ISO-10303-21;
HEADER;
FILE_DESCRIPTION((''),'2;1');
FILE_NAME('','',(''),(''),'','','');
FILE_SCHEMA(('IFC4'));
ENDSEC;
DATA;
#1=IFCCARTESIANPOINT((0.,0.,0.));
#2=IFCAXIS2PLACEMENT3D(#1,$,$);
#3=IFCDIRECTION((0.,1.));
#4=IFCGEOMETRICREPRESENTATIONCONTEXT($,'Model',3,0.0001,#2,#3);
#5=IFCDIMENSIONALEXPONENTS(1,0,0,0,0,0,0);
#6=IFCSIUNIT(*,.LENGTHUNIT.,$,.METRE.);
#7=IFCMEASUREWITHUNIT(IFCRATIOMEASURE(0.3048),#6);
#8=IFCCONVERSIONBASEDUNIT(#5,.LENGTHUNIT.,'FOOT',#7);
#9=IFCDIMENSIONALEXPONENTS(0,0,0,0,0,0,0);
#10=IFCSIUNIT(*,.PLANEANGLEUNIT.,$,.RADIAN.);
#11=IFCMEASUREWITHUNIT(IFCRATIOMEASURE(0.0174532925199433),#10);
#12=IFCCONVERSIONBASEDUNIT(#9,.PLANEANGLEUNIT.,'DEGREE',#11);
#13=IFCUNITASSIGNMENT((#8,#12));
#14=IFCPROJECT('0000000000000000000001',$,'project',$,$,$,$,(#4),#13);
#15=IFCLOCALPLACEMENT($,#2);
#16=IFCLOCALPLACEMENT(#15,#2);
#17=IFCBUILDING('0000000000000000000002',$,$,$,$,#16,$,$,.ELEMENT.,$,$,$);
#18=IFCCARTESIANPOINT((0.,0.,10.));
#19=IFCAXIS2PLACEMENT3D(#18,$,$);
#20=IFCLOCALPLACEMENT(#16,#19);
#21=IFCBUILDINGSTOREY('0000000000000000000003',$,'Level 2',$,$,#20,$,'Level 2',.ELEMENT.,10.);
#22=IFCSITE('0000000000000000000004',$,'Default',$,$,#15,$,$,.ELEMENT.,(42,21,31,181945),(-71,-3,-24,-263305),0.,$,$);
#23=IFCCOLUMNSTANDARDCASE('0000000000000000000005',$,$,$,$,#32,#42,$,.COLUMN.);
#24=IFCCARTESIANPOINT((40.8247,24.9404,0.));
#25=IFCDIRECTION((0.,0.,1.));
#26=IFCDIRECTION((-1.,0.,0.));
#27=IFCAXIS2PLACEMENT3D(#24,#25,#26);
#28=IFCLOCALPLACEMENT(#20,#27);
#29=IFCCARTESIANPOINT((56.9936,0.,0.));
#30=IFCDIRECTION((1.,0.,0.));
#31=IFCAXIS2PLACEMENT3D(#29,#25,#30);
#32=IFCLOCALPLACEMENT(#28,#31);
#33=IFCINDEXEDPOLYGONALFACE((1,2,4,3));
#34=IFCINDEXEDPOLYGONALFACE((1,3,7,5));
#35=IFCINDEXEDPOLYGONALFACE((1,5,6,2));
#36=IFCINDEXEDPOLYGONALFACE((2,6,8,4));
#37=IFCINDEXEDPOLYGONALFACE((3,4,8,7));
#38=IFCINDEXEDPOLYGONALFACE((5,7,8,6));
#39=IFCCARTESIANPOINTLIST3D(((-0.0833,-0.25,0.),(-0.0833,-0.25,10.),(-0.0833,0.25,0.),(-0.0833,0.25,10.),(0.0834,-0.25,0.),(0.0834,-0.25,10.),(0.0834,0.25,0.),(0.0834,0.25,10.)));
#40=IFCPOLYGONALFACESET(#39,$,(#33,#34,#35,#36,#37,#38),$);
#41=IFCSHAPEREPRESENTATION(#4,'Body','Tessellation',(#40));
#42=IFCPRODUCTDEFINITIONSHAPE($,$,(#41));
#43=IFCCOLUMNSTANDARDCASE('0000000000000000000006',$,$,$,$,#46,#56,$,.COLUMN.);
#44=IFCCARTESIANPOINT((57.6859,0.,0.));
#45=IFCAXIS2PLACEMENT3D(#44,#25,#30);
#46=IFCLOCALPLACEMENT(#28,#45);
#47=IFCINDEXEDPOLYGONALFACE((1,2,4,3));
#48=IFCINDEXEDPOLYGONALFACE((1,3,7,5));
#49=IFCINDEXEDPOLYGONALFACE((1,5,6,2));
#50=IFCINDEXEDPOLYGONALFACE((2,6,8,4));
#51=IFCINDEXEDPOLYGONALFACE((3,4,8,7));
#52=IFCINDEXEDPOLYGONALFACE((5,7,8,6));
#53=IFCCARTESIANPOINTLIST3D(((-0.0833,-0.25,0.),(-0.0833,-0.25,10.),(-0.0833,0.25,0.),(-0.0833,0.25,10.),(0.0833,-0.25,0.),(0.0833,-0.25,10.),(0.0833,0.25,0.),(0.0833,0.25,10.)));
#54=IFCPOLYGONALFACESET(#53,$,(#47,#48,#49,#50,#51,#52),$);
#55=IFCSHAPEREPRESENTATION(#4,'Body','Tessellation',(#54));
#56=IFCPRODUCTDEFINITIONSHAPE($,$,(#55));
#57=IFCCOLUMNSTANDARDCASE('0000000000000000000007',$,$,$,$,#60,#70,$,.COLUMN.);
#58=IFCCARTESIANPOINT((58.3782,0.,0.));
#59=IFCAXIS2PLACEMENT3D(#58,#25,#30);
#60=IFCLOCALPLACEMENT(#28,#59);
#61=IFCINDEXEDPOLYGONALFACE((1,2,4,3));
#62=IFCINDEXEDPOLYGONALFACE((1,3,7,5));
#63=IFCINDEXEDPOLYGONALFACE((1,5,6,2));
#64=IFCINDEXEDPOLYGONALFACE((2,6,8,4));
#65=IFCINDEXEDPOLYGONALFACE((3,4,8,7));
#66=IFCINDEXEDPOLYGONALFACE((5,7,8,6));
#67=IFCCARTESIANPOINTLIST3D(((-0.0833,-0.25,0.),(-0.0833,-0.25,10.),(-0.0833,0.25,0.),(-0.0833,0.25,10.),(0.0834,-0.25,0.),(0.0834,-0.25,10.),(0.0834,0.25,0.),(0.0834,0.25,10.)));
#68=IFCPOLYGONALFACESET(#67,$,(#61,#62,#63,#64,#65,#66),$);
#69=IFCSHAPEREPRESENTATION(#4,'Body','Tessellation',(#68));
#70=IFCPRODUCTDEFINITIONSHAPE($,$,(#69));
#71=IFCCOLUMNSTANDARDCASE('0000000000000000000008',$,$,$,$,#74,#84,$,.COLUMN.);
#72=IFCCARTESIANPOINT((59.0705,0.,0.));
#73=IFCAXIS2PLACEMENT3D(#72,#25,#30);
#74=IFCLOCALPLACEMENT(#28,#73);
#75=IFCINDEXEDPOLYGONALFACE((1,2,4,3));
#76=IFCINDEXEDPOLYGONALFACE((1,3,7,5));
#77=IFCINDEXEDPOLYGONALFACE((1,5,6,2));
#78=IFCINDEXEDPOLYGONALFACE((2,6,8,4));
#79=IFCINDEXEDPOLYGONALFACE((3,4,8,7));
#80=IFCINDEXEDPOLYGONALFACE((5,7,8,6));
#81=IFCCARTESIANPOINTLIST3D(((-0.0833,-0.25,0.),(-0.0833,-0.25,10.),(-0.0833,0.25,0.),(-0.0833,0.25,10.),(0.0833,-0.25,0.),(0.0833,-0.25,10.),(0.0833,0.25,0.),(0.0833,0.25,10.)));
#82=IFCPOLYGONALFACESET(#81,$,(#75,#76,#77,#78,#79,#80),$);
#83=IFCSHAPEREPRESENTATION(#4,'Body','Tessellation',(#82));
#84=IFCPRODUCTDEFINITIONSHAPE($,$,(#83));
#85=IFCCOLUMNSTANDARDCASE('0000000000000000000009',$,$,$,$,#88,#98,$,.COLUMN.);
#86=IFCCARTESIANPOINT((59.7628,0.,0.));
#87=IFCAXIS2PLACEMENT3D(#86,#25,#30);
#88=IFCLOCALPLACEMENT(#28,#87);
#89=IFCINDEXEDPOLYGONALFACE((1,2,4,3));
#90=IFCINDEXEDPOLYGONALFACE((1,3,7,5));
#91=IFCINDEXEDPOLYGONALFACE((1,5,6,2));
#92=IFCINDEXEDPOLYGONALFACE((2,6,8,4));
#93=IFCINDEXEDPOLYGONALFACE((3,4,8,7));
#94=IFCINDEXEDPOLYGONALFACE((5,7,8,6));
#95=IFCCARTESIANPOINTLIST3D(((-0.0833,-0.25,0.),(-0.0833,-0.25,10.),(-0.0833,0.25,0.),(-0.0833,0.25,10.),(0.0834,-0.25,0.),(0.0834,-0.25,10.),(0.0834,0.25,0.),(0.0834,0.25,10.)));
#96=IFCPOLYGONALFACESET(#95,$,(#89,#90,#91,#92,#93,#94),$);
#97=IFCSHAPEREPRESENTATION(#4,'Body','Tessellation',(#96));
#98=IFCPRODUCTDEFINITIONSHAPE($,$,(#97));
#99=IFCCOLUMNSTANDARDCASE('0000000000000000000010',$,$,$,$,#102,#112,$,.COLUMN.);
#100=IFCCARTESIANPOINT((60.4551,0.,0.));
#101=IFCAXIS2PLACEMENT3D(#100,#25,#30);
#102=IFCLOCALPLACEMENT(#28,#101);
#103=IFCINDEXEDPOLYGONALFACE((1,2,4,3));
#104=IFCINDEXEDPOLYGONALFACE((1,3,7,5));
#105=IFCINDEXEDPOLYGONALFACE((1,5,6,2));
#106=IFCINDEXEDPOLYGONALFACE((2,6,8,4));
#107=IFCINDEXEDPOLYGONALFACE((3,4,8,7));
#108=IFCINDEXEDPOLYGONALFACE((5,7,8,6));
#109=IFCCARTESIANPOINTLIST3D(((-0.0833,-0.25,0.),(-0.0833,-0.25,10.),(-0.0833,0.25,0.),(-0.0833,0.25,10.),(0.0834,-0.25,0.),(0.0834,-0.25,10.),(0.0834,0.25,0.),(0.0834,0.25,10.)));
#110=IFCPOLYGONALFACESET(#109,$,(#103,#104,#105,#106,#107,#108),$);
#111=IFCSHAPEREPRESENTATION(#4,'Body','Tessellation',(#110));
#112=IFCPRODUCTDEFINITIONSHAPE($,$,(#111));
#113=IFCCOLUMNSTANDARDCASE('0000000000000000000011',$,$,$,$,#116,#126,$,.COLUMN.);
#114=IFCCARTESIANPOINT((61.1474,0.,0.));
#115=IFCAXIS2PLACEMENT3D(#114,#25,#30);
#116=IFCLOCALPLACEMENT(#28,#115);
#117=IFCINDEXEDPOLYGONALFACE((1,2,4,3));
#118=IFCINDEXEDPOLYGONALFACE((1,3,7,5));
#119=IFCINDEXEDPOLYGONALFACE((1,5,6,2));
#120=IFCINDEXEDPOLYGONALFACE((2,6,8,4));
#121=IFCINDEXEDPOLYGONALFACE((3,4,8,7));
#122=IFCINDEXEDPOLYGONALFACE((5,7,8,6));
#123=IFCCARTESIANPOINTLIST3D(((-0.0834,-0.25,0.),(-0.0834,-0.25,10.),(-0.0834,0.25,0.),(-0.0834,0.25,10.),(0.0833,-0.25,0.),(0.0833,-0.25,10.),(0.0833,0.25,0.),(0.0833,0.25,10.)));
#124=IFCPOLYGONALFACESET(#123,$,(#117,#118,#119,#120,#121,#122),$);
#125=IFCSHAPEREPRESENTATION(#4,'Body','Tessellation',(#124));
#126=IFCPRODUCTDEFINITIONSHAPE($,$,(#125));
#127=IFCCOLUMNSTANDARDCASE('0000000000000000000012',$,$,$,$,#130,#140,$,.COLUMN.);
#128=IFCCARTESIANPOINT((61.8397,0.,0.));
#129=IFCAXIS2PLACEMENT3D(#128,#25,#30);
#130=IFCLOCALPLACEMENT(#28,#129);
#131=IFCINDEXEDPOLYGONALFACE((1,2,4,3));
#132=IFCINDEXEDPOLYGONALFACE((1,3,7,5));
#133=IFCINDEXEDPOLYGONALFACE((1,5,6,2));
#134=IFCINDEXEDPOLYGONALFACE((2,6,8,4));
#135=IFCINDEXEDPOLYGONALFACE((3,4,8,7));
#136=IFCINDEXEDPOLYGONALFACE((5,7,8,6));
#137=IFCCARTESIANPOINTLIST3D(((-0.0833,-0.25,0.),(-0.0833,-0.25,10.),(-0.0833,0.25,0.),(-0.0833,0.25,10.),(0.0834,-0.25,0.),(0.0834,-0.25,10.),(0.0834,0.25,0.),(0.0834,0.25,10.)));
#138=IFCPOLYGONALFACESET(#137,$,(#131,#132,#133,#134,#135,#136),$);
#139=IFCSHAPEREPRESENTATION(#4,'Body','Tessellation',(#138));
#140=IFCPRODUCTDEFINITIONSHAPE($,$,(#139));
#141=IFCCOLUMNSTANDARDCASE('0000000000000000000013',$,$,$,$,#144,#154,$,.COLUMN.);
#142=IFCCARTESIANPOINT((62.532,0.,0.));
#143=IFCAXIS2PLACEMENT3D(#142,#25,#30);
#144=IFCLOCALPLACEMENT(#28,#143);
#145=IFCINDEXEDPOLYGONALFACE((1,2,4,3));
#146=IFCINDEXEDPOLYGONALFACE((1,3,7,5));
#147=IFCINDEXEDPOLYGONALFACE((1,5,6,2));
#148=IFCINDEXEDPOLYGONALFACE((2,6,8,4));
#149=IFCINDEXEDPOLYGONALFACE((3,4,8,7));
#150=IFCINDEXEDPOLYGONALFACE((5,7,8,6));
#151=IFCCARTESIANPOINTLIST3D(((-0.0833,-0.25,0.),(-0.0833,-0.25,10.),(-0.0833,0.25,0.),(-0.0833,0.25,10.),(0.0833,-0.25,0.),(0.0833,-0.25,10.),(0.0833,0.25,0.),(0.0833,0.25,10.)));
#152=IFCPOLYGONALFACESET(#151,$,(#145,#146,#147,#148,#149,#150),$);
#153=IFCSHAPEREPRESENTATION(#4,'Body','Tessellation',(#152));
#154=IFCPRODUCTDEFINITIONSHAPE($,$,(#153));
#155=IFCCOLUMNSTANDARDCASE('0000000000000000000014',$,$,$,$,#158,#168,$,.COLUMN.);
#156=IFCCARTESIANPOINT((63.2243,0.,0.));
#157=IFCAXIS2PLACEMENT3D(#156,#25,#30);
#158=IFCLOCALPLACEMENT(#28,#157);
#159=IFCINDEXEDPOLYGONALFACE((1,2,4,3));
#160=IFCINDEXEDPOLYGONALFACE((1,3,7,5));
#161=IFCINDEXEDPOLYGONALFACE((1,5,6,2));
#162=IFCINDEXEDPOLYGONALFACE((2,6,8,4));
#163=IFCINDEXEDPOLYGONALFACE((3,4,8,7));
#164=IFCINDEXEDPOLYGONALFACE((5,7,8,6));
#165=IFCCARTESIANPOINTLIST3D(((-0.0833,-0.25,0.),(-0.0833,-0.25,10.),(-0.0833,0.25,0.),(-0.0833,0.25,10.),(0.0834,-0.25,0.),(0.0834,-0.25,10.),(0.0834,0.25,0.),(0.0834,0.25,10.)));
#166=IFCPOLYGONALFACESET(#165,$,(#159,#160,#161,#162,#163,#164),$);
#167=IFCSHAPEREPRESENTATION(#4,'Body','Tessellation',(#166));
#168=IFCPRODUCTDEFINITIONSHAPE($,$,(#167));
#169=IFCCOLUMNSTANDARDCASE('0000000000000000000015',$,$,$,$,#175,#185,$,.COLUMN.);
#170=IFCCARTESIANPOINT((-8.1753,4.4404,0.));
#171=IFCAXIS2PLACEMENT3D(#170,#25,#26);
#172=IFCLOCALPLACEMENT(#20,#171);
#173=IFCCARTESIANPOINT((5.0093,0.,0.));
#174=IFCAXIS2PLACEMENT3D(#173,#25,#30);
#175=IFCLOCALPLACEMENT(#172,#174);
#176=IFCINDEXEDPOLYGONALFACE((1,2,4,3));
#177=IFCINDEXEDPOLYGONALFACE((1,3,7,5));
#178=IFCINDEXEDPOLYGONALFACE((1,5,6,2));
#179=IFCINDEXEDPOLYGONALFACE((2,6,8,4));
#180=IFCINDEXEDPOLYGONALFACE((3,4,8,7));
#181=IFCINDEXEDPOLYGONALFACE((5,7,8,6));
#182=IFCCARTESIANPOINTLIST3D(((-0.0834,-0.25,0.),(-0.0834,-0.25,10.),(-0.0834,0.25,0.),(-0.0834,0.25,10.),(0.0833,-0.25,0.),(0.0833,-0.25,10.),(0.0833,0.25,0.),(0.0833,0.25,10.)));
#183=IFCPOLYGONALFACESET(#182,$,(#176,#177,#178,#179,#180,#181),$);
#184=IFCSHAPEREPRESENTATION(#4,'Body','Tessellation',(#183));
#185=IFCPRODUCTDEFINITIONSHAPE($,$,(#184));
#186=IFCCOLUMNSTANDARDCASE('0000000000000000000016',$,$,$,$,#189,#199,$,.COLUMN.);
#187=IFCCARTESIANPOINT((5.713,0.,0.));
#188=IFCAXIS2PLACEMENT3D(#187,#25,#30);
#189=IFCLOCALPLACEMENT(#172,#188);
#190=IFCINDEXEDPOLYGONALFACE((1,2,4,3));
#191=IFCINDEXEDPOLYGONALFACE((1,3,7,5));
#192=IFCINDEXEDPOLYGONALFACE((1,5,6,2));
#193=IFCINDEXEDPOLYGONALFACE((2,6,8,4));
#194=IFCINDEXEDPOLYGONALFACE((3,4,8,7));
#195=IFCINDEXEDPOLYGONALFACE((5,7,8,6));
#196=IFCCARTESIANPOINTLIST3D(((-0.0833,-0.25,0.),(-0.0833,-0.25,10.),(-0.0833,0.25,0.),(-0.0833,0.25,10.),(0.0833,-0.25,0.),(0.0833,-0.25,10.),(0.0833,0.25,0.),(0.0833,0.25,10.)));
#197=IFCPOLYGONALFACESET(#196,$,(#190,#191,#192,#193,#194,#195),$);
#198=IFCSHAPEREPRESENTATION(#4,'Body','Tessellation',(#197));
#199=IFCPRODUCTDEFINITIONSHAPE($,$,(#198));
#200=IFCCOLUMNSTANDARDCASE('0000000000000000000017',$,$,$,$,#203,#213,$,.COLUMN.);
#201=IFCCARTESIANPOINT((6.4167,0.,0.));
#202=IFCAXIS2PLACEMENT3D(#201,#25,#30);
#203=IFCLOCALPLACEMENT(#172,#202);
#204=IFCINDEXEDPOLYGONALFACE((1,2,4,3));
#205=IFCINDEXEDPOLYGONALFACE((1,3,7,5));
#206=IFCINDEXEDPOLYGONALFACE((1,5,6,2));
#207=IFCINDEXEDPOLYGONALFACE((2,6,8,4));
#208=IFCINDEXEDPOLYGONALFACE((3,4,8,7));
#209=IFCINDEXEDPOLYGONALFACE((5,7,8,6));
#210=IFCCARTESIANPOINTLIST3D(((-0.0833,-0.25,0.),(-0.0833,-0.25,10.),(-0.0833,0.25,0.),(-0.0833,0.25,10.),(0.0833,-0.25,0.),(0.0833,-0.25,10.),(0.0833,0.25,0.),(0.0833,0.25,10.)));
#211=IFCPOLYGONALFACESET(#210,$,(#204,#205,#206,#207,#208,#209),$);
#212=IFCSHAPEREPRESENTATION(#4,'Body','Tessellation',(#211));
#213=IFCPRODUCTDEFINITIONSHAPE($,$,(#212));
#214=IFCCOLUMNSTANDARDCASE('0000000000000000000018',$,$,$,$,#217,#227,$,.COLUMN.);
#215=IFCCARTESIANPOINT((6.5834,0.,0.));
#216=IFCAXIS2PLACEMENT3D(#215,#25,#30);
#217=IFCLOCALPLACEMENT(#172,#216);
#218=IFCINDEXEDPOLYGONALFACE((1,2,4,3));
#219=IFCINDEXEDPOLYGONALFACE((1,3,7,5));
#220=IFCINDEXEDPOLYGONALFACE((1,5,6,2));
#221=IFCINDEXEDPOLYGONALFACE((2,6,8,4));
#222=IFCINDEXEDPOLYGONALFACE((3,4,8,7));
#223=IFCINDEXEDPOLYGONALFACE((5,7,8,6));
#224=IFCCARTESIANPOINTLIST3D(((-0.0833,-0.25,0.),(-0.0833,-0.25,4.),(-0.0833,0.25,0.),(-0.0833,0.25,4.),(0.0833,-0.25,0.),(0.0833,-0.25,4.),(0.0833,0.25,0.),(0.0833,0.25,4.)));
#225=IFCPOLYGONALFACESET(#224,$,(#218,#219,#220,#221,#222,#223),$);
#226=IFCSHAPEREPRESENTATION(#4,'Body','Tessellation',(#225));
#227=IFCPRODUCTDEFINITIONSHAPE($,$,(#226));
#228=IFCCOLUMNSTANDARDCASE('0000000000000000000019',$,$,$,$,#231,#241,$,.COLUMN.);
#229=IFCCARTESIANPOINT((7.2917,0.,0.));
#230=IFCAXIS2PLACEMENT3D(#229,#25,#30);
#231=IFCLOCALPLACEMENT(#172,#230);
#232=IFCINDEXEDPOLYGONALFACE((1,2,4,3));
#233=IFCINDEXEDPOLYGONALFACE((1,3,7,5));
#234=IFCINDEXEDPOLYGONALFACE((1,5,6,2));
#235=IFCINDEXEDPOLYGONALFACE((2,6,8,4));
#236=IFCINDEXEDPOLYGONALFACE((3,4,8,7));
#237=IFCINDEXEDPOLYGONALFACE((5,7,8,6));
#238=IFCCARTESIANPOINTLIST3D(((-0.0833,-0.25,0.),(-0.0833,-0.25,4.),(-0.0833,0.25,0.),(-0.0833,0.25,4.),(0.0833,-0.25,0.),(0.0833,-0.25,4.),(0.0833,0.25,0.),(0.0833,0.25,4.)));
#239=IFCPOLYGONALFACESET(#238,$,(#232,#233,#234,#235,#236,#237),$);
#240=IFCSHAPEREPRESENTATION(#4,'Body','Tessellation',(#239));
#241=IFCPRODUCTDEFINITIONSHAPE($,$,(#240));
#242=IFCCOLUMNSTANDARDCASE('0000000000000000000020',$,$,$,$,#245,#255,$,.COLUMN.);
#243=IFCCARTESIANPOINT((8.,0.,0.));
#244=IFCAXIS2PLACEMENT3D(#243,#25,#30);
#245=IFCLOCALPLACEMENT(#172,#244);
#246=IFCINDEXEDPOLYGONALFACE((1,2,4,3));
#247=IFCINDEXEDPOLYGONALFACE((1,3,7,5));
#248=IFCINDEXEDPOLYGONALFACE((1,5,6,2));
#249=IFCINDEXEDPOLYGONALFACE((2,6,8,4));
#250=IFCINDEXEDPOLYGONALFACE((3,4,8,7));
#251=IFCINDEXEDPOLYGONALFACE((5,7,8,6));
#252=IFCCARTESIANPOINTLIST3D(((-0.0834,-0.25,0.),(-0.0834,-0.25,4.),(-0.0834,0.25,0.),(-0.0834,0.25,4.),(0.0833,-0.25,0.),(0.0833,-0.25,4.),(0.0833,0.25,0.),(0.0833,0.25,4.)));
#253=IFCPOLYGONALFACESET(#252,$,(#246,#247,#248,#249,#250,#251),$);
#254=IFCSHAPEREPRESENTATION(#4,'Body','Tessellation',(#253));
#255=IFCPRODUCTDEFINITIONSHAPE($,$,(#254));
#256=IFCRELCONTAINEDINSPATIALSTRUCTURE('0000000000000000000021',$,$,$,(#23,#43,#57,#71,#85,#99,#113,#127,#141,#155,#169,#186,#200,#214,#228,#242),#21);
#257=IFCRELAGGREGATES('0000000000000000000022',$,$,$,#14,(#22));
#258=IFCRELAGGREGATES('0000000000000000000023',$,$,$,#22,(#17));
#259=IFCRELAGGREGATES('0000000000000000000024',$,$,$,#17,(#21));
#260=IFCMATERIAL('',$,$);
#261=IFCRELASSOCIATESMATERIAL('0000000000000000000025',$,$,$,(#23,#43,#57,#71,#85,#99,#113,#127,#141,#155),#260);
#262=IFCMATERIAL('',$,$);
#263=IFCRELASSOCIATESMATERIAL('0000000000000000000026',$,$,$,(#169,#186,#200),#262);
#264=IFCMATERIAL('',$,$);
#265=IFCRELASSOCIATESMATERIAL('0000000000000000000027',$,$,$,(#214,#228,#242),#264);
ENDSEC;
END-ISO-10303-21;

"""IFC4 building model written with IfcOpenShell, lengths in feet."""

from ifc_helpers import new_model, entity, si_unit, converted_unit, direction, frame, origin, place, context, project, spatial, rectangle, extrude, material, element, save


model = new_model("IFC4")

# Units and contexts
model_context = context("Model", 3, precision=0.0001, world=origin(), true_north=direction((0.0, 1.0)))
ifc_project = project(units=[converted_unit("LENGTHUNIT", "FOOT", entity("IfcRatioMeasure", 0.3048), si_unit("LENGTHUNIT", "METRE"), dimensions=[1, 0, 0, 0, 0, 0, 0]), converted_unit("PLANEANGLEUNIT", "DEGREE", entity("IfcRatioMeasure", 0.0174532925199433), si_unit("PLANEANGLEUNIT", "RADIAN"), dimensions=[0, 0, 0, 0, 0, 0, 0])], contexts=[model_context])

# Site, building, storey
site_placement = place(None, origin())
site = spatial("IfcSite", under=ifc_project, at=site_placement, Name="Default", CompositionType="ELEMENT", RefLatitude=(42, 21, 31, 181945), RefLongitude=(-71, -3, -24, -263305), RefElevation=0.0)
building_placement = place(site_placement, origin())
building = spatial("IfcBuilding", under=site, at=building_placement, CompositionType="ELEMENT")
storey_placement = place(building_placement, frame((0.0, 0.0, 10.0)))
storey = spatial("IfcBuildingStorey", under=building, at=storey_placement, Name="Level 2", LongName="Level 2", CompositionType="ELEMENT", Elevation=10.0)

# Columns
ifc_material_1 = material(Name="")
placement_1 = place(storey_placement, frame((40.8247, 24.9404, 0.0), z_axis=(0.0, 0.0, 1.0), x_axis=(-1.0, 0.0, 0.0)))
for number, where, z_axis, x_axis in (
    (1, (56.9936, 0.0, 0.0), (0.0, 0.0, 1.0), (1.0, 0.0, 0.0)),
    (2, (57.6859, 0.0, 0.0), (0.0, 0.0, 1.0), (1.0, 0.0, 0.0)),
    (3, (58.3782, 0.0, 0.0), (0.0, 0.0, 1.0), (1.0, 0.0, 0.0)),
    (4, (59.0705, 0.0, 0.0), (0.0, 0.0, 1.0), (1.0, 0.0, 0.0)),
    (5, (59.7628, 0.0, 0.0), (0.0, 0.0, 1.0), (1.0, 0.0, 0.0)),
    (6, (60.4551, 0.0, 0.0), (0.0, 0.0, 1.0), (1.0, 0.0, 0.0)),
    (7, (61.1474, 0.0, 0.0), (0.0, 0.0, 1.0), (1.0, 0.0, 0.0)),
    (8, (61.8397, 0.0, 0.0), (0.0, 0.0, 1.0), (1.0, 0.0, 0.0)),
    (9, (62.532, 0.0, 0.0), (0.0, 0.0, 1.0), (1.0, 0.0, 0.0)),
    (10, (63.2243, 0.0, 0.0), (0.0, 0.0, 1.0), (1.0, 0.0, 0.0)),
):
    element("IfcColumnStandardCase", number, at=place(placement_1, frame(where, z_axis=z_axis, x_axis=x_axis)), inside=storey, material=ifc_material_1, PredefinedType="COLUMN", context=model_context, shape_type="SweptSolid", body=[
        extrude(rectangle(XDim=0.1667, YDim=0.5), origin(), (0.0, 0.0, 1.0), 10.0),
    ])
ifc_material_2 = material(Name="")
placement_2 = place(storey_placement, frame((-8.1753, 4.4404, 0.0), z_axis=(0.0, 0.0, 1.0), x_axis=(-1.0, 0.0, 0.0)))
for number, where, z_axis, x_axis in (
    (11, (5.0093, 0.0, 0.0), (0.0, 0.0, 1.0), (1.0, 0.0, 0.0)),
    (12, (5.713, 0.0, 0.0), (0.0, 0.0, 1.0), (1.0, 0.0, 0.0)),
    (13, (6.4167, 0.0, 0.0), (0.0, 0.0, 1.0), (1.0, 0.0, 0.0)),
):
    element("IfcColumnStandardCase", number, at=place(placement_2, frame(where, z_axis=z_axis, x_axis=x_axis)), inside=storey, material=ifc_material_2, PredefinedType="COLUMN", context=model_context, shape_type="SweptSolid", body=[
        extrude(rectangle(XDim=0.1667, YDim=0.5), origin(), (0.0, 0.0, 1.0), 10.0),
    ])
ifc_material_3 = material(Name="")
for number, where, z_axis, x_axis in (
    (14, (6.5834, 0.0, 0.0), (0.0, 0.0, 1.0), (1.0, 0.0, 0.0)),
    (15, (7.2917, 0.0, 0.0), (0.0, 0.0, 1.0), (1.0, 0.0, 0.0)),
    (16, (8.0, 0.0, 0.0), (0.0, 0.0, 1.0), (1.0, 0.0, 0.0)),
):
    element("IfcColumnStandardCase", number, at=place(placement_2, frame(where, z_axis=z_axis, x_axis=x_axis)), inside=storey, material=ifc_material_3, PredefinedType="COLUMN", context=model_context, shape_type="SweptSolid", body=[
        extrude(rectangle(XDim=0.1667, YDim=0.5), origin(), (0.0, 0.0, 1.0), 4.0),
    ])

save(model, "model.ifc")
